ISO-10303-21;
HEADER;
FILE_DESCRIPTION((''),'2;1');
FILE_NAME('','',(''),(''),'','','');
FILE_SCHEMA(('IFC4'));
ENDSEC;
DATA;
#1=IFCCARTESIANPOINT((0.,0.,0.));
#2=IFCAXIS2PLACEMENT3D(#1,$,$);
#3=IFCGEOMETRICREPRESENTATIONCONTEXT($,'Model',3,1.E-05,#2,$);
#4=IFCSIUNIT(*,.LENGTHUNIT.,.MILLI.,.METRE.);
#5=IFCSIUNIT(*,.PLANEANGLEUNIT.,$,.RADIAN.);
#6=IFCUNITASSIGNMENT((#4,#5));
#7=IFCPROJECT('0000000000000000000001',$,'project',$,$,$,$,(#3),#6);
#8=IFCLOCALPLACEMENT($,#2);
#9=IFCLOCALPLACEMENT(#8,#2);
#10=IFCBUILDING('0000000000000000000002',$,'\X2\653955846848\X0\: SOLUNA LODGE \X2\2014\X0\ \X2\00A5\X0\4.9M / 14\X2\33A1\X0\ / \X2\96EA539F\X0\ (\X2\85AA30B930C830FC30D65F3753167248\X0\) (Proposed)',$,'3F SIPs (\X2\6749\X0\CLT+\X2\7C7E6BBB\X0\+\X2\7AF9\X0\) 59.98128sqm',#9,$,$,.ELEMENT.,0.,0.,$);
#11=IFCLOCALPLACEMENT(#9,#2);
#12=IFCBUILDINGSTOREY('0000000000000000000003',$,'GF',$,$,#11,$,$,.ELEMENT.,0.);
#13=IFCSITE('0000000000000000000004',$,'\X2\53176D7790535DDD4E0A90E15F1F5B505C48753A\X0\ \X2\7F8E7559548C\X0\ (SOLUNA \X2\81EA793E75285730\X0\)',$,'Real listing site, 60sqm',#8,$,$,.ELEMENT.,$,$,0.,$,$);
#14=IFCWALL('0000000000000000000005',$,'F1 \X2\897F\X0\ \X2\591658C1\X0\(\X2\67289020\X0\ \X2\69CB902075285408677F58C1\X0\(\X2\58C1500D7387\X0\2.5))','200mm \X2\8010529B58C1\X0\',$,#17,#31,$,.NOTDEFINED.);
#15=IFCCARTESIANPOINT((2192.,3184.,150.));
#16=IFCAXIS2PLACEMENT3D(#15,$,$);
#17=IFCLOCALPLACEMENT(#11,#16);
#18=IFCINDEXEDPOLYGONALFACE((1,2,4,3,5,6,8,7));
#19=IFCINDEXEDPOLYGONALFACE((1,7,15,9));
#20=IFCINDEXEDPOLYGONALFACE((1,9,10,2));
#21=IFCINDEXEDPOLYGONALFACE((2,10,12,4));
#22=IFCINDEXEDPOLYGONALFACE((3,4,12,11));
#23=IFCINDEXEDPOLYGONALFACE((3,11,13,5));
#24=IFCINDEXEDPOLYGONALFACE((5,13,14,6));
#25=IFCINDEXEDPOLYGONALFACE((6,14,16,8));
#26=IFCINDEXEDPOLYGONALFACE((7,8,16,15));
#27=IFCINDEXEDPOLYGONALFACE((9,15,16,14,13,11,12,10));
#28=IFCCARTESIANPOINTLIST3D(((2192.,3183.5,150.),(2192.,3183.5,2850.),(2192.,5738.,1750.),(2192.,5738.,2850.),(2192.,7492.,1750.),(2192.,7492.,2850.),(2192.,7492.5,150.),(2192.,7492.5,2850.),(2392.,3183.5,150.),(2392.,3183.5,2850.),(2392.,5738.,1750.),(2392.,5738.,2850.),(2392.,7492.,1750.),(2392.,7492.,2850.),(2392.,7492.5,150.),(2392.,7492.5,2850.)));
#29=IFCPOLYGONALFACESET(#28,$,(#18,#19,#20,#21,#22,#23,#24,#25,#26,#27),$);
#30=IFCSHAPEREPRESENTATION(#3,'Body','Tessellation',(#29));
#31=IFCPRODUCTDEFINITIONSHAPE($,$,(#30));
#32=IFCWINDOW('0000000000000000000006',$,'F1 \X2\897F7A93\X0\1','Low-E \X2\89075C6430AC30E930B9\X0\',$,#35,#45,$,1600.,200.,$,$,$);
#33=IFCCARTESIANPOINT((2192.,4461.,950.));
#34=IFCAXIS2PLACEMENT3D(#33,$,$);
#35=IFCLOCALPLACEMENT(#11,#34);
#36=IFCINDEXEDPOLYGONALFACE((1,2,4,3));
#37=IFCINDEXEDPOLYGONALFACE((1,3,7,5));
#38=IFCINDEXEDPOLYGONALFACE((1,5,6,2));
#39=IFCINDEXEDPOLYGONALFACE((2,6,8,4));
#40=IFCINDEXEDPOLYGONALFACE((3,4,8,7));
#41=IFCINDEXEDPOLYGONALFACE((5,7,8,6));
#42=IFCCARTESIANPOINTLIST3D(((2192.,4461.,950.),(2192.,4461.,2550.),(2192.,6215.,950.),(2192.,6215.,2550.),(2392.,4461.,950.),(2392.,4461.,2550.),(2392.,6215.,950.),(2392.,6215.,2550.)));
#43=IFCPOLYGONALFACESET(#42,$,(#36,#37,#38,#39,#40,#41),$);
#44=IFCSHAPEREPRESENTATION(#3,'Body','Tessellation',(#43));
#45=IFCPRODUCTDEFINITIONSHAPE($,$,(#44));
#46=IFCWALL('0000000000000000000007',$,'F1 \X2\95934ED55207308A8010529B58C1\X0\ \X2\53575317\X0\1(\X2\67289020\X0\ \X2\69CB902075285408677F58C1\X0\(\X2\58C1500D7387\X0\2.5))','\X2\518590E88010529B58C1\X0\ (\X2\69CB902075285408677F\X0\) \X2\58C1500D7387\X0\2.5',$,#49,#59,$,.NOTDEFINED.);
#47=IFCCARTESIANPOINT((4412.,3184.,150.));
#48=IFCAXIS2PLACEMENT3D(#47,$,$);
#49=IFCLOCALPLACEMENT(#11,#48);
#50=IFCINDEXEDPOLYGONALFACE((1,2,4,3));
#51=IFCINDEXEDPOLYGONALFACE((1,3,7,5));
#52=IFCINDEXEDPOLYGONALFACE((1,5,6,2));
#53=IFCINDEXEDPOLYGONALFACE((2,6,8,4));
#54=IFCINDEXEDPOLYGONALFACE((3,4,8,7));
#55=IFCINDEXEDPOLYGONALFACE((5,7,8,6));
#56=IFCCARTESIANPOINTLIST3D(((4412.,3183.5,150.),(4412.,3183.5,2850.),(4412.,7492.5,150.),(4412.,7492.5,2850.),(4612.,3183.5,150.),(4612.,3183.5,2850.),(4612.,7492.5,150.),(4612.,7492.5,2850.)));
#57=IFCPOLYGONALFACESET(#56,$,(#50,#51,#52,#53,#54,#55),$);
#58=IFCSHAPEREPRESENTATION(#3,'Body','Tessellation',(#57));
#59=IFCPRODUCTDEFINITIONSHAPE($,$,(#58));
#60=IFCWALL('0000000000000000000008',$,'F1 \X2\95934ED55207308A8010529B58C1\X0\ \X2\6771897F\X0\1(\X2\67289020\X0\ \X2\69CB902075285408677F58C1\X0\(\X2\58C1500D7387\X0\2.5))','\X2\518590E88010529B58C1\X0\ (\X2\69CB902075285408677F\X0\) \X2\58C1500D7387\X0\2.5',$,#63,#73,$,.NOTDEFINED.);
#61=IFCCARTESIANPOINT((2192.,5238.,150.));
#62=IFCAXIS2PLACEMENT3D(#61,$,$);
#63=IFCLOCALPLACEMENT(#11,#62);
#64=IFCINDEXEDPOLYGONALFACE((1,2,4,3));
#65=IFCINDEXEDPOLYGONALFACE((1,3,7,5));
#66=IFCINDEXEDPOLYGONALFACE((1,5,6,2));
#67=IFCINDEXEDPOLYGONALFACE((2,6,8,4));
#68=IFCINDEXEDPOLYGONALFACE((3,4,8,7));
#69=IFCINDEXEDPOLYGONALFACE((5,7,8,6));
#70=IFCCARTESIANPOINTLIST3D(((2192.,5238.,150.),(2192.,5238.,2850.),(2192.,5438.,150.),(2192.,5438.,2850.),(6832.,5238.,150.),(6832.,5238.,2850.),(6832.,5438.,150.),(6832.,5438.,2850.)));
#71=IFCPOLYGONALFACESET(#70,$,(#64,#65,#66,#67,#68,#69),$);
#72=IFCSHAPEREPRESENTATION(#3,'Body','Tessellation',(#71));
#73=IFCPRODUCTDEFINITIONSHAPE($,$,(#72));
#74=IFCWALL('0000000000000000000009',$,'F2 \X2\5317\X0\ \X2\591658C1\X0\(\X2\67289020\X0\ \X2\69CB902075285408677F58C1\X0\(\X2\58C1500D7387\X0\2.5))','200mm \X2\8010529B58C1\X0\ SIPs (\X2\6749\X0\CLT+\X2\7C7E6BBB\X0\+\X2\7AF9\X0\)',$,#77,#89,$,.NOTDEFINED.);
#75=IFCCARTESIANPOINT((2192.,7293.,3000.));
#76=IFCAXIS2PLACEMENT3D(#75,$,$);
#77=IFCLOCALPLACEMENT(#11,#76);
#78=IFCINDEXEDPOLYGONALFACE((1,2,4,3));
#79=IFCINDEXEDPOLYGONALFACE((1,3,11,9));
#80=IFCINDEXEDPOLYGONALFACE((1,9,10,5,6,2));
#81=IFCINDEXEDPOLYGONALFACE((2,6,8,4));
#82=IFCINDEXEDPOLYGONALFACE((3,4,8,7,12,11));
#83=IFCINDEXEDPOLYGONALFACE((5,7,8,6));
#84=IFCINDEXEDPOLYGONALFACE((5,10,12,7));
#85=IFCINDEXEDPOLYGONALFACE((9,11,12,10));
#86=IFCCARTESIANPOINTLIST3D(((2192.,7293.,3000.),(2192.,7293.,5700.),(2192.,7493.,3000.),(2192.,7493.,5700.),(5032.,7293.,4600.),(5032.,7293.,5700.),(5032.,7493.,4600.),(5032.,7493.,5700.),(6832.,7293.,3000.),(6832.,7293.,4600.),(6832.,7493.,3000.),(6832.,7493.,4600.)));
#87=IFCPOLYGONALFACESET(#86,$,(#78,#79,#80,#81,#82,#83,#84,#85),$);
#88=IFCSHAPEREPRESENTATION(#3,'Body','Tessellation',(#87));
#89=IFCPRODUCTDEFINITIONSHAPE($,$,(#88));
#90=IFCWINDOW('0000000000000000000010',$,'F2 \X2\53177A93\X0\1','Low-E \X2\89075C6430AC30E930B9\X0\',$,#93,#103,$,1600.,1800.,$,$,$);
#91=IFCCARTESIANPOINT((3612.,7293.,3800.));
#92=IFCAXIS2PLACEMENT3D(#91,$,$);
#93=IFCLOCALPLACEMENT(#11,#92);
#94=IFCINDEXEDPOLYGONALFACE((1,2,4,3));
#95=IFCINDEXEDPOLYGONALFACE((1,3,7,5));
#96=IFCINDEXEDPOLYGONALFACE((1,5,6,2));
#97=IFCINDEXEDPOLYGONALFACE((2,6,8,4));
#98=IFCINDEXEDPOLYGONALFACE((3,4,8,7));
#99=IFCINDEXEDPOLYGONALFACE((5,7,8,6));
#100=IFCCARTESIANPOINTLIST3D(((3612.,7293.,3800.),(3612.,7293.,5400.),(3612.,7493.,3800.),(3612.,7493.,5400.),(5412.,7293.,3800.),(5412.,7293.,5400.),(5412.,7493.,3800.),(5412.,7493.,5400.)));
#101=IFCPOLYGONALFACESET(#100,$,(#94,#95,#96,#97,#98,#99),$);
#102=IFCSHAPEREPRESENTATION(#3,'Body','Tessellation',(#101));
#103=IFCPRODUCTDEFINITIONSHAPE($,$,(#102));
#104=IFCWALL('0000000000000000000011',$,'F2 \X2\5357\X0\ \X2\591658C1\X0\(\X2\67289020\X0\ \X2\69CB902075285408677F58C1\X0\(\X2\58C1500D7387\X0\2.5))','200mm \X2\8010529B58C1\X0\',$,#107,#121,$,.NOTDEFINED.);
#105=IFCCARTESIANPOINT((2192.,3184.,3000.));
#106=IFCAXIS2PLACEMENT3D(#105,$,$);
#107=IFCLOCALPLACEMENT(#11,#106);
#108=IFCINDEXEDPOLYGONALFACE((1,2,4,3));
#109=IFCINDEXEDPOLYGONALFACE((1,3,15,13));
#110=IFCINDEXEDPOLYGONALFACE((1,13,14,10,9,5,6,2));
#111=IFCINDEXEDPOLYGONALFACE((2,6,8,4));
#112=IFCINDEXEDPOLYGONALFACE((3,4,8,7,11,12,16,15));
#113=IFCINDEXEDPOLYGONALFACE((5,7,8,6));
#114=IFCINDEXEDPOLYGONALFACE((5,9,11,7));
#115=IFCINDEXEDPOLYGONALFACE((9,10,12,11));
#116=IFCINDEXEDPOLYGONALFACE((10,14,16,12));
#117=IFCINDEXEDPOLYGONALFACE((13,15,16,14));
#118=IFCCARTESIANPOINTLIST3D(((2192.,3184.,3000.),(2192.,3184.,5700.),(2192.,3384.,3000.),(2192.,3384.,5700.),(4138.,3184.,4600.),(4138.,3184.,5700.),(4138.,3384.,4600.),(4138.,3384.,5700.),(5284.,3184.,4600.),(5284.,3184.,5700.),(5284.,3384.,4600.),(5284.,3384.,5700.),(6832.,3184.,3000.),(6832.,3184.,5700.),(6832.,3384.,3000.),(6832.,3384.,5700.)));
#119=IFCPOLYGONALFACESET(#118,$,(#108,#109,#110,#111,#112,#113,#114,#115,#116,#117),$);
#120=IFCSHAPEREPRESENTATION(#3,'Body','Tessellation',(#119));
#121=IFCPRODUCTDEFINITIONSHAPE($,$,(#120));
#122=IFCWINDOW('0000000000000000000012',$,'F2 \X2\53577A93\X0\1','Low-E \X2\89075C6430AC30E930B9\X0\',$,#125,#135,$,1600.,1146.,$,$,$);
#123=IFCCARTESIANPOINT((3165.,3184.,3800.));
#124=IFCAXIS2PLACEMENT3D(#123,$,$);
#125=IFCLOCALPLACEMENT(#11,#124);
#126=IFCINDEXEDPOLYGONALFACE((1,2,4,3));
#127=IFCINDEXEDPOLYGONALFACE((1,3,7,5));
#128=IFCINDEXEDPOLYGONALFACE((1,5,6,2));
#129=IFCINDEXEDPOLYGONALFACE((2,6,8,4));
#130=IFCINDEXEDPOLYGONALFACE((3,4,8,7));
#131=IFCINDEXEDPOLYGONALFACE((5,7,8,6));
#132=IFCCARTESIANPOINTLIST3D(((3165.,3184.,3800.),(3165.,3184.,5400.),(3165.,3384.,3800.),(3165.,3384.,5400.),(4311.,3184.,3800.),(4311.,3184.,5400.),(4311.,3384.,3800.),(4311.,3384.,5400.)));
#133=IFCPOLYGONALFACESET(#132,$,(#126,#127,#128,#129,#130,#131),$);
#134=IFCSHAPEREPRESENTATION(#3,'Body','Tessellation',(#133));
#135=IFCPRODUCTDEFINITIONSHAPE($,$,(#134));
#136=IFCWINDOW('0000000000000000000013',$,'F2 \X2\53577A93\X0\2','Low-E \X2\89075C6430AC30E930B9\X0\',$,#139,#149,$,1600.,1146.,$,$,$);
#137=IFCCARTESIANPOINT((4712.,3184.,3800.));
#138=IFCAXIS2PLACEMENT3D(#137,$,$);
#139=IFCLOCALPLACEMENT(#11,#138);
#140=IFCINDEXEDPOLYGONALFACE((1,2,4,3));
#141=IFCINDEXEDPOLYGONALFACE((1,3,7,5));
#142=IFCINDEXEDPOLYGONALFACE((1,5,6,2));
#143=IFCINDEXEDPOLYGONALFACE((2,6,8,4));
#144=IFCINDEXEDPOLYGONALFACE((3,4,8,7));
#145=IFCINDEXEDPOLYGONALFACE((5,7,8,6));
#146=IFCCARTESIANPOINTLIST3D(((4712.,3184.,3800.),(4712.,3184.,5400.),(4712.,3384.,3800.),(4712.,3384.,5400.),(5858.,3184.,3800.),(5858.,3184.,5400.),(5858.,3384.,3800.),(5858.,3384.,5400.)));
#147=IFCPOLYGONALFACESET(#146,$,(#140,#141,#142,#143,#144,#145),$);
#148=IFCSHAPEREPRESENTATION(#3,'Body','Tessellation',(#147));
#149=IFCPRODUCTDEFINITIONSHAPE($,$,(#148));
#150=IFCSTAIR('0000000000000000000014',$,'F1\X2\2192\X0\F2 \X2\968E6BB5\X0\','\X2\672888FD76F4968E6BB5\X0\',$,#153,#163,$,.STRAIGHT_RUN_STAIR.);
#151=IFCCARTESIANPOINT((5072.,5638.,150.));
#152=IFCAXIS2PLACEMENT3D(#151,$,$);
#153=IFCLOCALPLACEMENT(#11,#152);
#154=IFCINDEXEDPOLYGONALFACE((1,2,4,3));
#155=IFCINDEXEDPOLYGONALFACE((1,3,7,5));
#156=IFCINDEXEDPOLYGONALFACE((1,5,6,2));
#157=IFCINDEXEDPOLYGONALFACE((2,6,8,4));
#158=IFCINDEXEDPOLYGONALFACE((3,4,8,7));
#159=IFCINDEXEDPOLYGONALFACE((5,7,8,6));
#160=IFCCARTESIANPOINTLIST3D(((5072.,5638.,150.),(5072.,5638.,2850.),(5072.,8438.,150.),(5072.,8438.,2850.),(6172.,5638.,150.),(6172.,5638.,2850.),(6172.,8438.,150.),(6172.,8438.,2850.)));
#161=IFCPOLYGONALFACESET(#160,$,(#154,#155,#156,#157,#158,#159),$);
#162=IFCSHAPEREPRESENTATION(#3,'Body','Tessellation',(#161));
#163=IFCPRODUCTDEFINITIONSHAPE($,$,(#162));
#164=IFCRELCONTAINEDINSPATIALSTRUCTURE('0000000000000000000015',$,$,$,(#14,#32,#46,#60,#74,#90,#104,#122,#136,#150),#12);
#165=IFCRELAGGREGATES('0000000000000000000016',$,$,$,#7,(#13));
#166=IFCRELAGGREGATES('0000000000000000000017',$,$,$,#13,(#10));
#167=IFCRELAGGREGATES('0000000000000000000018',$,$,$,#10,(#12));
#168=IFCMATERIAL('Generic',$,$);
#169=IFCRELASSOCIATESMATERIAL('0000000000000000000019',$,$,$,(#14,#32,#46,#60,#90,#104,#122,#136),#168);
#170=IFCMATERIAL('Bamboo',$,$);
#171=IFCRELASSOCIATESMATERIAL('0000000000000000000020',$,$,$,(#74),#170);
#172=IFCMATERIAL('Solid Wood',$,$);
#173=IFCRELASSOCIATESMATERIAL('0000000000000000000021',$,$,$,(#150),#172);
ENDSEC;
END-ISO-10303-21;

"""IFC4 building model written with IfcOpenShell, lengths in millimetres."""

from ifc_helpers import new_model, si_unit, frame, frame_2d, origin, place, context, project, spatial, rectangle, extrude, material, element, fill, save


model = new_model("IFC4")

# Units and contexts
model_context = context("Model", 3, precision=1e-05, world=origin())
ifc_project = project(units=[si_unit("LENGTHUNIT", "METRE", prefix="MILLI"), si_unit("PLANEANGLEUNIT", "RADIAN")], contexts=[model_context])

# Site, building, storey
site_placement = place(None, origin())
site = spatial("IfcSite", under=ifc_project, at=site_placement, Name="北海道川上郡弟子屈町 美留和 (SOLUNA 自社用地)", ObjectType="Real listing site, 60sqm", CompositionType="ELEMENT", RefElevation=0.0)
building_placement = place(site_placement, origin())
building = spatial("IfcBuilding", under=site, at=building_placement, Name="改善案: SOLUNA LODGE — ¥4.9M / 14㎡ / 雪原 (薪ストーブ強化版) (Proposed)", ObjectType="3F SIPs (杉CLT+籾殻+竹) 59.98128sqm", CompositionType="ELEMENT", ElevationOfRefHeight=0.0, ElevationOfTerrain=0.0)
storey_placement = place(building_placement, origin())
storey = spatial("IfcBuildingStorey", under=building, at=storey_placement, Name="GF", CompositionType="ELEMENT", Elevation=0.0)

# Shared definitions
ifc_material_1 = material(Name="Generic")

# Shared definitions
ifc_material_2 = material(Name="Bamboo")

# Shared definitions
ifc_material_3 = material(Name="Solid Wood")

# Wall, opening, window
wall_1_placement = place(storey_placement, frame((2192.0, 3184.0, 150.0)))
wall_1 = element("IfcWall", 1, at=wall_1_placement, inside=storey, material=ifc_material_1, Name="F1 西 外壁(木造 構造用合板壁(壁倍率2.5))", Description="200mm 耐力壁", PredefinedType="NOTDEFINED", context=model_context, shape_type="SweptSolid", body=[
    extrude(rectangle(XDim=200.0, YDim=4309.0, at=frame_2d((100.0, 2154.0))), frame((2192.0, 3184.0, 150.0)), (0.0, 0.0, 1.0), 2700.0),
])
opening_1_placement = place(storey_placement, frame((2192.0, 4461.0, 950.0)))
opening_1 = element("IfcOpeningElement", 2, at=opening_1_placement, cuts=wall_1, PredefinedType="NOTDEFINED", context=model_context, shape_type="SweptSolid", body=[
    extrude(rectangle(XDim=200.0, YDim=1754.0, at=frame_2d((100.0, 877.0))), frame((2192.0, 4461.0, 950.0)), (0.0, 0.0, 1.0), 1600.0),
])
window_1_placement = place(storey_placement, frame((2192.0, 4461.0, 950.0)))
window_1 = element("IfcWindow", 3, at=window_1_placement, inside=storey, material=ifc_material_1, Name="F1 西窓1", Description="Low-E 複層ガラス", OverallHeight=1600.0, OverallWidth=200.0, context=model_context, shape_type="SweptSolid", body=[
    extrude(rectangle(XDim=200.0, YDim=1754.0, at=frame_2d((100.0, 877.0))), frame((2192.0, 4461.0, 950.0)), (0.0, 0.0, 1.0), 1600.0),
])
fill(opening_1, window_1)

# Walls
wall_2_placement = place(storey_placement, frame((4412.0, 3184.0, 150.0)))
element("IfcWall", 4, at=wall_2_placement, inside=storey, material=ifc_material_1, Name="F1 間仕切り耐力壁 南北1(木造 構造用合板壁(壁倍率2.5))", Description="内部耐力壁 (構造用合板) 壁倍率2.5", PredefinedType="NOTDEFINED", context=model_context, shape_type="SweptSolid", body=[
    extrude(rectangle(XDim=200.0, YDim=4309.0, at=frame_2d((100.0, 2154.0))), frame((4412.0, 3184.0, 150.0)), (0.0, 0.0, 1.0), 2700.0),
])
wall_3_placement = place(storey_placement, frame((2192.0, 5238.0, 150.0)))
element("IfcWall", 5, at=wall_3_placement, inside=storey, material=ifc_material_1, Name="F1 間仕切り耐力壁 東西1(木造 構造用合板壁(壁倍率2.5))", Description="内部耐力壁 (構造用合板) 壁倍率2.5", PredefinedType="NOTDEFINED", context=model_context, shape_type="SweptSolid", body=[
    extrude(rectangle(XDim=4640.0, YDim=200.0, at=frame_2d((2320.0, 100.0))), frame((2192.0, 5238.0, 150.0)), (0.0, 0.0, 1.0), 2700.0),
])

# Wall, opening, window
wall_4_placement = place(storey_placement, frame((2192.0, 7293.0, 3000.0)))
wall_4 = element("IfcWall", 6, at=wall_4_placement, inside=storey, material=ifc_material_2, Name="F2 北 外壁(木造 構造用合板壁(壁倍率2.5))", Description="200mm 耐力壁 SIPs (杉CLT+籾殻+竹)", PredefinedType="NOTDEFINED", context=model_context, shape_type="SweptSolid", body=[
    extrude(rectangle(XDim=4640.0, YDim=200.0, at=frame_2d((2320.0, 100.0))), frame((2192.0, 7293.0, 3000.0)), (0.0, 0.0, 1.0), 2700.0),
])
opening_2_placement = place(storey_placement, frame((3612.0, 7293.0, 3800.0)))
opening_2 = element("IfcOpeningElement", 7, at=opening_2_placement, cuts=wall_4, PredefinedType="NOTDEFINED", context=model_context, shape_type="SweptSolid", body=[
    extrude(rectangle(XDim=1800.0, YDim=200.0, at=frame_2d((900.0, 100.0))), frame((3612.0, 7293.0, 3800.0)), (0.0, 0.0, 1.0), 1600.0),
])
window_2_placement = place(storey_placement, frame((3612.0, 7293.0, 3800.0)))
window_2 = element("IfcWindow", 8, at=window_2_placement, inside=storey, material=ifc_material_1, Name="F2 北窓1", Description="Low-E 複層ガラス", OverallHeight=1600.0, OverallWidth=1800.0, context=model_context, shape_type="SweptSolid", body=[
    extrude(rectangle(XDim=1800.0, YDim=200.0, at=frame_2d((900.0, 100.0))), frame((3612.0, 7293.0, 3800.0)), (0.0, 0.0, 1.0), 1600.0),
])
fill(opening_2, window_2)

# Wall, openings, windows
wall_5_placement = place(storey_placement, frame((2192.0, 3184.0, 3000.0)))
wall_5 = element("IfcWall", 9, at=wall_5_placement, inside=storey, material=ifc_material_1, Name="F2 南 外壁(木造 構造用合板壁(壁倍率2.5))", Description="200mm 耐力壁", PredefinedType="NOTDEFINED", context=model_context, shape_type="SweptSolid", body=[
    extrude(rectangle(XDim=4640.0, YDim=200.0, at=frame_2d((2320.0, 100.0))), frame((2192.0, 3184.0, 3000.0)), (0.0, 0.0, 1.0), 2700.0),
])
opening_3_placement = place(storey_placement, frame((3165.0, 3184.0, 3800.0)))
opening_3 = element("IfcOpeningElement", 10, at=opening_3_placement, cuts=wall_5, PredefinedType="NOTDEFINED", context=model_context, shape_type="SweptSolid", body=[
    extrude(rectangle(XDim=1146.0, YDim=200.0, at=frame_2d((573.0, 100.0))), frame((3165.0, 3184.0, 3800.0)), (0.0, 0.0, 1.0), 1600.0),
])
opening_4_placement = place(storey_placement, frame((4712.0, 3184.0, 3800.0)))
opening_4 = element("IfcOpeningElement", 11, at=opening_4_placement, cuts=wall_5, PredefinedType="NOTDEFINED", context=model_context, shape_type="SweptSolid", body=[
    extrude(rectangle(XDim=1146.0, YDim=200.0, at=frame_2d((573.0, 100.0))), frame((4712.0, 3184.0, 3800.0)), (0.0, 0.0, 1.0), 1600.0),
])
window_3_placement = place(storey_placement, frame((3165.0, 3184.0, 3800.0)))
window_3 = element("IfcWindow", 12, at=window_3_placement, inside=storey, material=ifc_material_1, Name="F2 南窓1", Description="Low-E 複層ガラス", OverallHeight=1600.0, OverallWidth=1146.0, context=model_context, shape_type="SweptSolid", body=[
    extrude(rectangle(XDim=1146.0, YDim=200.0, at=frame_2d((573.0, 100.0))), frame((3165.0, 3184.0, 3800.0)), (0.0, 0.0, 1.0), 1600.0),
])
fill(opening_3, window_3)
window_4_placement = place(storey_placement, frame((4712.0, 3184.0, 3800.0)))
window_4 = element("IfcWindow", 13, at=window_4_placement, inside=storey, material=ifc_material_1, Name="F2 南窓2", Description="Low-E 複層ガラス", OverallHeight=1600.0, OverallWidth=1146.0, context=model_context, shape_type="SweptSolid", body=[
    extrude(rectangle(XDim=1146.0, YDim=200.0, at=frame_2d((573.0, 100.0))), frame((4712.0, 3184.0, 3800.0)), (0.0, 0.0, 1.0), 1600.0),
])
fill(opening_4, window_4)

# Stair
stair_placement = place(storey_placement, frame((5072.0, 5638.0, 150.0)))
element("IfcStair", 14, at=stair_placement, inside=storey, material=ifc_material_3, Name="F1→F2 階段", Description="木製直階段", PredefinedType="STRAIGHT_RUN_STAIR", context=model_context, shape_type="SweptSolid", body=[
    extrude(rectangle(XDim=1100.0, YDim=2800.0, at=frame_2d((550.0, 1400.0))), frame((5072.0, 5638.0, 150.0)), (0.0, 0.0, 1.0), 2700.0),
])

save(model, "model.ifc")
